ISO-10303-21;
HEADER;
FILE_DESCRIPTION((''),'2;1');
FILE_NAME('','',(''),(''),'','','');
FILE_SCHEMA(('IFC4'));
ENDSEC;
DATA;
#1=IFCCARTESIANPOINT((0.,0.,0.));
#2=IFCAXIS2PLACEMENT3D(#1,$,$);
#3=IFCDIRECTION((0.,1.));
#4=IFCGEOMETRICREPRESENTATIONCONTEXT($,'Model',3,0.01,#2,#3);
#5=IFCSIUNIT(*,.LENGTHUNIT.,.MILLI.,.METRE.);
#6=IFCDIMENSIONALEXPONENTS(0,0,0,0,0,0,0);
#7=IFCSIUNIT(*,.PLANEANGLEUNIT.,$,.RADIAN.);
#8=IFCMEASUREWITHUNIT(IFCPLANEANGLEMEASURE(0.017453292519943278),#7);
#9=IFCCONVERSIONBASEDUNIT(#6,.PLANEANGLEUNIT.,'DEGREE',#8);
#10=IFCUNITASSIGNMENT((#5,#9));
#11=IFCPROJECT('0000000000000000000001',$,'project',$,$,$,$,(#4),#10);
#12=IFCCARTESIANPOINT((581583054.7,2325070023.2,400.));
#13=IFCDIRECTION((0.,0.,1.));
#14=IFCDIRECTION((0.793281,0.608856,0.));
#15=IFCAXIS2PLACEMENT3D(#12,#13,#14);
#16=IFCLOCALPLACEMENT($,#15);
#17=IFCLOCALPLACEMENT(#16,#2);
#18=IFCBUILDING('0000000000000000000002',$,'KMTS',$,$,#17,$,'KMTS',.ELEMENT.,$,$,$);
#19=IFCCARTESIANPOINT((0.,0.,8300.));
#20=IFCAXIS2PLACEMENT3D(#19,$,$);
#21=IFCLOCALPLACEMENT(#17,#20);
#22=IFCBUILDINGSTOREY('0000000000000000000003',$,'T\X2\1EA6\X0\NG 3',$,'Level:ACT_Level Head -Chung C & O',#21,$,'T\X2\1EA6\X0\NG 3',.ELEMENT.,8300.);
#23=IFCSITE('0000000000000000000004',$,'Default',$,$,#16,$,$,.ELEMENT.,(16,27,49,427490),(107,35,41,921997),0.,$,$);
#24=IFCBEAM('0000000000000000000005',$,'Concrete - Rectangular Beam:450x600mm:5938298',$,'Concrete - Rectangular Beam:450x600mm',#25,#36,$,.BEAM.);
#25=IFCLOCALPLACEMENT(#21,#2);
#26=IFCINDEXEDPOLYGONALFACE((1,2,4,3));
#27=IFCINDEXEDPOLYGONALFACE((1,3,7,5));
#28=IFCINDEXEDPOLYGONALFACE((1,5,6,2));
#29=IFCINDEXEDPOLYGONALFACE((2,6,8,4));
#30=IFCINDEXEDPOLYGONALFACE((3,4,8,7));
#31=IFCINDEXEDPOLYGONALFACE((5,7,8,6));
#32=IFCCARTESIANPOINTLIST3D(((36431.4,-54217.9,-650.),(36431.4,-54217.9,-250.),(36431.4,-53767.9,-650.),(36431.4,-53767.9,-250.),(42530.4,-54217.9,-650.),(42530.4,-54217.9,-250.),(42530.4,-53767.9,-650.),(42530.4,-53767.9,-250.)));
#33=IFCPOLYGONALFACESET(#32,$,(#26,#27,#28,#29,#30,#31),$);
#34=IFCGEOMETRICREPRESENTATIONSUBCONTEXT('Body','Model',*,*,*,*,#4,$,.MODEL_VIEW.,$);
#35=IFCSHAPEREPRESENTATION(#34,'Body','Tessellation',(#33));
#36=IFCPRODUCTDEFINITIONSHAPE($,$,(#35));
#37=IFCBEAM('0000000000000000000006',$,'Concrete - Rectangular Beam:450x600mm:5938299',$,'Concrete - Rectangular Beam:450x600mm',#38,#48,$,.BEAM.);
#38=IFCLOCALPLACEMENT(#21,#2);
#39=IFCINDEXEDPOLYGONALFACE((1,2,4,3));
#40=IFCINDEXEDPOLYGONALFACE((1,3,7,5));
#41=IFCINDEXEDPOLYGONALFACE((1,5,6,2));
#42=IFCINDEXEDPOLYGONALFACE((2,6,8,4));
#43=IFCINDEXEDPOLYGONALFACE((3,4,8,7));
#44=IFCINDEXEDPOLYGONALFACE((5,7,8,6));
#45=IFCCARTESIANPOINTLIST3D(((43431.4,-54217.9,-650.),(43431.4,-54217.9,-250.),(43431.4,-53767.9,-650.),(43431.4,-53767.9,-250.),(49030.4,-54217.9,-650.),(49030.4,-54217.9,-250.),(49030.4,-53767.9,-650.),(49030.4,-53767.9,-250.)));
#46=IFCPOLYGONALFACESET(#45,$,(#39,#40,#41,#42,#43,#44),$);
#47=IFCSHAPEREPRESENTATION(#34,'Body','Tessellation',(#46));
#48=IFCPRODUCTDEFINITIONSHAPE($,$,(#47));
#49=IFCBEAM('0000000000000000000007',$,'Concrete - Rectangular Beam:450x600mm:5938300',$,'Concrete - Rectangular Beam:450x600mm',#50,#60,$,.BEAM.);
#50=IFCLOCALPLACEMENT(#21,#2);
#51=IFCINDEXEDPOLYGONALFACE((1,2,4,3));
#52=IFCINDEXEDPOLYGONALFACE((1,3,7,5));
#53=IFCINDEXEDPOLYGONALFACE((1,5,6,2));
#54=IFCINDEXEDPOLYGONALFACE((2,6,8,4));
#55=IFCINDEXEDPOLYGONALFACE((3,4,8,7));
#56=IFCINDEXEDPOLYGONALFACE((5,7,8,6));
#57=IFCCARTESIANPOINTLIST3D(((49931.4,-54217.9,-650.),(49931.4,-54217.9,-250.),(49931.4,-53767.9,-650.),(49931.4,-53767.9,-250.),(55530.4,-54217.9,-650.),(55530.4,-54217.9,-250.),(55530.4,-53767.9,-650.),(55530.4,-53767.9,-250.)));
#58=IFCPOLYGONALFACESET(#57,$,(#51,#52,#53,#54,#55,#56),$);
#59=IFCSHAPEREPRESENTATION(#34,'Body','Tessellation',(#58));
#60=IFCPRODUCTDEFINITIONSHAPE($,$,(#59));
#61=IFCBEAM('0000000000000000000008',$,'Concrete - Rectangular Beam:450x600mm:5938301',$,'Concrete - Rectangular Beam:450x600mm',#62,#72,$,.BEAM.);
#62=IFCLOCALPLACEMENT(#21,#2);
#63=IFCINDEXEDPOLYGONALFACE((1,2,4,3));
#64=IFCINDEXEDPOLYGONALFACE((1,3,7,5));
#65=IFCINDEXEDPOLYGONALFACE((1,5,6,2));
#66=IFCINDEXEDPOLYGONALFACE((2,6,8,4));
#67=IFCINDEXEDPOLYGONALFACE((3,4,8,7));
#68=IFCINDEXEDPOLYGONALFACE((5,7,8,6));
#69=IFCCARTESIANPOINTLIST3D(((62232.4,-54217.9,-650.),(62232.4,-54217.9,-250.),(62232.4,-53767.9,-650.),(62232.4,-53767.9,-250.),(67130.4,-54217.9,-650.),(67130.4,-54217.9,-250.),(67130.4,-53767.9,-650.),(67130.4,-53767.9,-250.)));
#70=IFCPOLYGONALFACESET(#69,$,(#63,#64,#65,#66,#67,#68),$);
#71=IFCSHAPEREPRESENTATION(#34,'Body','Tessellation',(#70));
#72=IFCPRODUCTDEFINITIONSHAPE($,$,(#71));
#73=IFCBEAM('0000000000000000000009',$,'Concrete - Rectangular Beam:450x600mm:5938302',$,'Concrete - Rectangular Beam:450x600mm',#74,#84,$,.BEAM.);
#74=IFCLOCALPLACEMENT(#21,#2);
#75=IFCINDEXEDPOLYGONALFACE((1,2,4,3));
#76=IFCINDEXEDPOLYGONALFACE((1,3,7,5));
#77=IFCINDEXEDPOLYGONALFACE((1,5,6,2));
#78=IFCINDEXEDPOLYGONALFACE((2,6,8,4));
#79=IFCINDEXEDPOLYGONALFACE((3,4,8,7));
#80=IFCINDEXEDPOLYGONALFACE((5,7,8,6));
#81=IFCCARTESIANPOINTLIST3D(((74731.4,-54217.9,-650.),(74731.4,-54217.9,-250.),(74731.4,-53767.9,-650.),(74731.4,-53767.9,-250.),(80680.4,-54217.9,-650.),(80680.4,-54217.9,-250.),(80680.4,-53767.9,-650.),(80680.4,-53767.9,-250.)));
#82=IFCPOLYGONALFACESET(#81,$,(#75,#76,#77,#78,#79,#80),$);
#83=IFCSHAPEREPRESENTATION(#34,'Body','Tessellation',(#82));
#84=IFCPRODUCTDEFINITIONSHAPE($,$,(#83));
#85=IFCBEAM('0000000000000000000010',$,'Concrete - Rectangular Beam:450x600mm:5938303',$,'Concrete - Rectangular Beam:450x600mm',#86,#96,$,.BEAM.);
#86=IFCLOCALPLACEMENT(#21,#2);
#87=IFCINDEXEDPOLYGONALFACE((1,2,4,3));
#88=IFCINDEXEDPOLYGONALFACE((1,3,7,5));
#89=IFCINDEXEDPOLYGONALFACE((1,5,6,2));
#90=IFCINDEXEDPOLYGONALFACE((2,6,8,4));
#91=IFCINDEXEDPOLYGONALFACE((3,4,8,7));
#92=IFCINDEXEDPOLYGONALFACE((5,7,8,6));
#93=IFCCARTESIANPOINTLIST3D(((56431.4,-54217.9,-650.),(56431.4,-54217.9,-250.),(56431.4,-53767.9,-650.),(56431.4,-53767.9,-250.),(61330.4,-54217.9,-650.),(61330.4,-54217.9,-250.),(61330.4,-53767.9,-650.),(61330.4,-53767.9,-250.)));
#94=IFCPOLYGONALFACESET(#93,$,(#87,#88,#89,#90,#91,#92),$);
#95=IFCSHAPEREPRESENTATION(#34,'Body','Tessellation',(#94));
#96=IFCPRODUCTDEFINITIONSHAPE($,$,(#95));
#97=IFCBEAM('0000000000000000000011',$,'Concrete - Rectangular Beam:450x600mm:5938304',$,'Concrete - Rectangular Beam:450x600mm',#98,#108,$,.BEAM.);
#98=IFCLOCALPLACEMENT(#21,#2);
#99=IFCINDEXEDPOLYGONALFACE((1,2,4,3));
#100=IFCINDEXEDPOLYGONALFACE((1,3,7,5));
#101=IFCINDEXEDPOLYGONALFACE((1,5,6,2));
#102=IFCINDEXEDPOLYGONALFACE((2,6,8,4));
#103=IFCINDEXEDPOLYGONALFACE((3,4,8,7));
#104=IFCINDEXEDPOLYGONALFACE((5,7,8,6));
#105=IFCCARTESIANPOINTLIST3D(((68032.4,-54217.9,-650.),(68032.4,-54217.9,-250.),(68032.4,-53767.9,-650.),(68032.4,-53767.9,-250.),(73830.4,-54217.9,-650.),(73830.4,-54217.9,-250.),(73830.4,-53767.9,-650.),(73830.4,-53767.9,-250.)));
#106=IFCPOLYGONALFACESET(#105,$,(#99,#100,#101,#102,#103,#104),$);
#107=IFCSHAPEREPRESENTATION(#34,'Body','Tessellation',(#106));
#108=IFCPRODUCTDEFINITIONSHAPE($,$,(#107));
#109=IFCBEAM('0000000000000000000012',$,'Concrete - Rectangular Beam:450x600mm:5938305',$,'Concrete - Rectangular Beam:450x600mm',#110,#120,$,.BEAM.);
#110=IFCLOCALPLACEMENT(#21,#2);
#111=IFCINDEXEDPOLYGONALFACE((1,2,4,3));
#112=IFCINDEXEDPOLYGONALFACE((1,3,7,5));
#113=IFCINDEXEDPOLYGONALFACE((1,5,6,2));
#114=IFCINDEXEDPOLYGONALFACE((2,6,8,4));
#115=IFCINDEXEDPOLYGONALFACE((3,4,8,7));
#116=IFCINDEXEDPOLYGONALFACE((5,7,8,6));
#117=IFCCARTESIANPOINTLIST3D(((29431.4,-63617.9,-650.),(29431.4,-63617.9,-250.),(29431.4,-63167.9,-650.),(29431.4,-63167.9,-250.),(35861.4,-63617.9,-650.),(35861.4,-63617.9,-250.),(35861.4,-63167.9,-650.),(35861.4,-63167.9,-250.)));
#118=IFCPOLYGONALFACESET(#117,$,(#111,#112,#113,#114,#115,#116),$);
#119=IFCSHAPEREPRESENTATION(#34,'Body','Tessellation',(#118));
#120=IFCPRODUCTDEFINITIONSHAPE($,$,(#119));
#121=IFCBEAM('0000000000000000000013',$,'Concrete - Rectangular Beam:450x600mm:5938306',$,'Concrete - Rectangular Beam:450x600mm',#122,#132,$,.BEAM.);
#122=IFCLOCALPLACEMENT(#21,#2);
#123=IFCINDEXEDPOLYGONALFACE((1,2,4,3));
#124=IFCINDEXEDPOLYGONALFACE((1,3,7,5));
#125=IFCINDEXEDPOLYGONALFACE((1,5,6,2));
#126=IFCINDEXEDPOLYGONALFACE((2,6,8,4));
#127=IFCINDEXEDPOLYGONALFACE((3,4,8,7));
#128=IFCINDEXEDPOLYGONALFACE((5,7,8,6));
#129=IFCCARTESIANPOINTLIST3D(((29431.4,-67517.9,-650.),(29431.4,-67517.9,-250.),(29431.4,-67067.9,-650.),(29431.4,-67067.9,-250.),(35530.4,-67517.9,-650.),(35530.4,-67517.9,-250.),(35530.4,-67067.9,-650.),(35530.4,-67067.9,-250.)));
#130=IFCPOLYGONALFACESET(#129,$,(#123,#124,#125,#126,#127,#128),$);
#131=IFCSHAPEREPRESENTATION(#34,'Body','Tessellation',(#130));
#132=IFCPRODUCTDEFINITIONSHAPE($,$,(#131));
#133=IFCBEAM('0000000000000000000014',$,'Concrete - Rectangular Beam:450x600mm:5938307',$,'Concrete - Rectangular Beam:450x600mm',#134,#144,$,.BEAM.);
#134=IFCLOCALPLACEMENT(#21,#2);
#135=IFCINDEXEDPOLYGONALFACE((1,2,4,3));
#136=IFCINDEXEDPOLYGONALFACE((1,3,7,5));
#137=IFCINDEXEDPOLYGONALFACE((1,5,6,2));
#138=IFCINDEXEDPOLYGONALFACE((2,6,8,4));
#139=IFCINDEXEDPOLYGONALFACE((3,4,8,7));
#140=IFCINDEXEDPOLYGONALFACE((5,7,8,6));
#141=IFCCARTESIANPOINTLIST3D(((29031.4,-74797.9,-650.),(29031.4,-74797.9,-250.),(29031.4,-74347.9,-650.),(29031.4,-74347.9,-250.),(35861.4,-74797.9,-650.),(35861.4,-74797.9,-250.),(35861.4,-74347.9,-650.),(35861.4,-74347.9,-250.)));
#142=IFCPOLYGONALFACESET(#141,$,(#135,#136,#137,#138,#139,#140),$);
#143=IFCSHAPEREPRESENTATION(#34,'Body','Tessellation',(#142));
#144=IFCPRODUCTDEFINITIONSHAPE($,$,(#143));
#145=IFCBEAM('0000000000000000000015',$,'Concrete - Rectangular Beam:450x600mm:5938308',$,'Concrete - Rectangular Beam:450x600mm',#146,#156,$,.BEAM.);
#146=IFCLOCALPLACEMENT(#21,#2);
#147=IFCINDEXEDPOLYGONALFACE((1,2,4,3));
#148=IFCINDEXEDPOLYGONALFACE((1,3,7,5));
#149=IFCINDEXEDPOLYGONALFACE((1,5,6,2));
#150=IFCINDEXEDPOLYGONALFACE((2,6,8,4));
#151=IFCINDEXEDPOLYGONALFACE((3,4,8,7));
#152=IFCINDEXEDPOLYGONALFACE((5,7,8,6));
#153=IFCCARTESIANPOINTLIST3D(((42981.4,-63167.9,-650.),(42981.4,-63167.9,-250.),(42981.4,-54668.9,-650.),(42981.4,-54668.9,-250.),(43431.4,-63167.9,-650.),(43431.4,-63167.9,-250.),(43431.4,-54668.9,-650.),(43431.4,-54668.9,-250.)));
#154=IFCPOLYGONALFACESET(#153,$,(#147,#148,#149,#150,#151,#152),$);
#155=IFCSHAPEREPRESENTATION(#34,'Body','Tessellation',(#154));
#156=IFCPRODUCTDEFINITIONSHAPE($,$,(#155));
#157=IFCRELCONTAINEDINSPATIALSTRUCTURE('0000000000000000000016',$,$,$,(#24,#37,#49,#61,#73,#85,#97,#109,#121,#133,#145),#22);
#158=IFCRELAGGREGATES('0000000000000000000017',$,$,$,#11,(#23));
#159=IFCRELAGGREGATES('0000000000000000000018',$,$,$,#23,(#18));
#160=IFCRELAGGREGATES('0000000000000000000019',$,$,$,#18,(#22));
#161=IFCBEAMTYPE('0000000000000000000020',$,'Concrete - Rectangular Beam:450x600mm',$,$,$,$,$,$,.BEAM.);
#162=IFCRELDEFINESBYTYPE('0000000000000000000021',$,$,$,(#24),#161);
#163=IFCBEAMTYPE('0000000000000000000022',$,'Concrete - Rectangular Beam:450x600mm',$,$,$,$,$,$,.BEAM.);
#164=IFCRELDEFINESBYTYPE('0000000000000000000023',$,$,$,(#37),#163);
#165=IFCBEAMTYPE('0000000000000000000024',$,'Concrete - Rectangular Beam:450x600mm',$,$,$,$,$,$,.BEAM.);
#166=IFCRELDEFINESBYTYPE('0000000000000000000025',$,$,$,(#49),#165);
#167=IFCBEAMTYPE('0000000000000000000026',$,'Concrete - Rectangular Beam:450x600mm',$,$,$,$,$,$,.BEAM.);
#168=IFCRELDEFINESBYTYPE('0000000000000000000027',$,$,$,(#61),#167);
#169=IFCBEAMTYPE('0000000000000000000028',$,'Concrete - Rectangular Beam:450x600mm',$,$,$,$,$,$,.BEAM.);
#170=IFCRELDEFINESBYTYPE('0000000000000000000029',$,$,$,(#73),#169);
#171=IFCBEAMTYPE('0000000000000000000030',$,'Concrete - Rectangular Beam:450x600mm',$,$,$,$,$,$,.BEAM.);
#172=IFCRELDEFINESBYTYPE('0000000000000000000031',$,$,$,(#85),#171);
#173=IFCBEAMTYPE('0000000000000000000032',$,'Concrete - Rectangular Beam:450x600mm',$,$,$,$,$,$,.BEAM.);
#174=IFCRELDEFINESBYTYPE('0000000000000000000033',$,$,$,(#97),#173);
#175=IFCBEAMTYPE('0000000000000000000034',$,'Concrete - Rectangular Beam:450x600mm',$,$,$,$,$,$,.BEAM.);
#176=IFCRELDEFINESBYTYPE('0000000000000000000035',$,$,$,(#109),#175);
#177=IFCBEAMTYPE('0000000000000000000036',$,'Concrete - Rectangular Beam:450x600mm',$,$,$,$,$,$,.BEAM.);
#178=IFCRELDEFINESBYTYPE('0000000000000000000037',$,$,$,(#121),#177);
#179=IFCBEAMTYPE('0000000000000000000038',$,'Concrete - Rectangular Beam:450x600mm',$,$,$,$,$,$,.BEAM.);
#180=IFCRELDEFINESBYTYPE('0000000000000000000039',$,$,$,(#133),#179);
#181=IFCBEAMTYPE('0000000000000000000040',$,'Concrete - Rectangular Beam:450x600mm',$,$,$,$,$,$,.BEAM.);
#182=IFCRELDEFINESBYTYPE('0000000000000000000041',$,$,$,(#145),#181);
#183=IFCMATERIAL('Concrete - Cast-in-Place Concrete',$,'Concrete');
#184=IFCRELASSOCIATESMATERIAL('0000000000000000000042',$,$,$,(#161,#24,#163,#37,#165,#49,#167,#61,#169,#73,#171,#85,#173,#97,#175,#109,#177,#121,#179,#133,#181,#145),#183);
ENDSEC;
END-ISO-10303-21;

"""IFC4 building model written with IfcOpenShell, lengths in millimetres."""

from ifc_helpers import new_model, entity, si_unit, converted_unit, direction, frame, origin, place, context, subcontext, project, spatial, indexed_curve, outline, extrude, source, transform, mapped, material, type_object, type_shapes, element, save


model = new_model("IFC4")

# Units and contexts
model_context = context("Model", 3, precision=0.01, world=origin(), true_north=direction((0.0, 1.0)))
body_context = subcontext(model_context, "Body", "Model", "MODEL_VIEW")
ifc_project = project(units=[si_unit("LENGTHUNIT", "METRE", prefix="MILLI"), converted_unit("PLANEANGLEUNIT", "DEGREE", entity("IfcPlaneAngleMeasure", 0.017453292519943278), si_unit("PLANEANGLEUNIT", "RADIAN"), dimensions=[0, 0, 0, 0, 0, 0, 0])], contexts=[model_context])

# Site, building, storey
site_placement = place(None, frame((581583054.7, 2325070023.2, 400.0), z_axis=(0.0, 0.0, 1.0), x_axis=(0.793281, 0.608856, 0.0)))
site = spatial("IfcSite", under=ifc_project, at=site_placement, Name="Default", CompositionType="ELEMENT", RefLatitude=(16, 27, 49, 427490), RefLongitude=(107, 35, 41, 921997), RefElevation=0.0)
building_placement = place(site_placement, origin())
building = spatial("IfcBuilding", under=site, at=building_placement, Name="KMTS", LongName="KMTS", CompositionType="ELEMENT")
storey_placement = place(building_placement, frame((0.0, 0.0, 8300.0)))
storey = spatial("IfcBuildingStorey", under=building, at=storey_placement, Name="TẦNG 3", ObjectType="Level:ACT_Level Head -Chung C & O", LongName="TẦNG 3", CompositionType="ELEMENT", Elevation=8300.0)

# Beams
ifc_material = material(Name="Concrete - Cast-in-Place Concrete", Category="Concrete")
beam_type_1 = type_object("IfcBeamType", Name="Concrete - Rectangular Beam:450x600mm", PredefinedType="BEAM", material=ifc_material)
shared_shape_1 = source(origin(), body_context, "Body", "SweptSolid", [
    extrude(outline(indexed_curve([(-200.0, -225.0), (200.0, -225.0), (200.0, 225.0), (-200.0, 225.0), (-200.0, -225.0)], self_intersect=False)), frame((36431.4, -53992.9, 7850.0), z_axis=(1.0, 0.0, 0.0), x_axis=(0.0, 0.0, -1.0)), (0.0, 0.0, 1.0), 6099.0),
])
type_shapes(beam_type_1, [shared_shape_1])
beam_1_placement = place(storey_placement, frame((0.0, 0.0, -8300.0)))
element("IfcBeam", 1, at=beam_1_placement, inside=storey, type_object=beam_type_1, material=ifc_material, Name="Concrete - Rectangular Beam:450x600mm:5938298", ObjectType="Concrete - Rectangular Beam:450x600mm", PredefinedType="BEAM", context=body_context, shape_type="MappedRepresentation", body=[
    mapped(shared_shape_1, transform((0.0, 0.0, 0.0), scale=1.0)),
])
beam_type_2 = type_object("IfcBeamType", Name="Concrete - Rectangular Beam:450x600mm", PredefinedType="BEAM", material=ifc_material)
shared_shape_2 = source(origin(), body_context, "Body", "SweptSolid", [
    extrude(outline(indexed_curve([(-200.0, -225.0), (200.0, -225.0), (200.0, 225.0), (-200.0, 225.0), (-200.0, -225.0)], self_intersect=False)), frame((43431.4, -53992.9, 7850.0), z_axis=(1.0, 0.0, 0.0), x_axis=(0.0, 0.0, -1.0)), (0.0, 0.0, 1.0), 5599.0),
])
type_shapes(beam_type_2, [shared_shape_2])
beam_2_placement = place(storey_placement, frame((0.0, 0.0, -8300.0)))
element("IfcBeam", 2, at=beam_2_placement, inside=storey, type_object=beam_type_2, material=ifc_material, Name="Concrete - Rectangular Beam:450x600mm:5938299", ObjectType="Concrete - Rectangular Beam:450x600mm", PredefinedType="BEAM", context=body_context, shape_type="MappedRepresentation", body=[
    mapped(shared_shape_2, transform((0.0, 0.0, 0.0), scale=1.0)),
])
beam_type_3 = type_object("IfcBeamType", Name="Concrete - Rectangular Beam:450x600mm", PredefinedType="BEAM", material=ifc_material)
shared_shape_3 = source(origin(), body_context, "Body", "SweptSolid", [
    extrude(outline(indexed_curve([(-200.0, -225.0), (200.0, -225.0), (200.0, 225.0), (-200.0, 225.0), (-200.0, -225.0)], self_intersect=False)), frame((49931.4, -53992.9, 7850.0), z_axis=(1.0, 0.0, 0.0), x_axis=(0.0, 0.0, -1.0)), (0.0, 0.0, 1.0), 5599.0),
])
type_shapes(beam_type_3, [shared_shape_3])
beam_3_placement = place(storey_placement, frame((0.0, 0.0, -8300.0)))
element("IfcBeam", 3, at=beam_3_placement, inside=storey, type_object=beam_type_3, material=ifc_material, Name="Concrete - Rectangular Beam:450x600mm:5938300", ObjectType="Concrete - Rectangular Beam:450x600mm", PredefinedType="BEAM", context=body_context, shape_type="MappedRepresentation", body=[
    mapped(shared_shape_3, transform((0.0, 0.0, 0.0), scale=1.0)),
])
beam_type_4 = type_object("IfcBeamType", Name="Concrete - Rectangular Beam:450x600mm", PredefinedType="BEAM", material=ifc_material)
shared_shape_4 = source(origin(), body_context, "Body", "SweptSolid", [
    extrude(outline(indexed_curve([(-200.0, -225.0), (200.0, -225.0), (200.0, 225.0), (-200.0, 225.0), (-200.0, -225.0)], self_intersect=False)), frame((62232.4, -53992.9, 7850.0), z_axis=(1.0, 0.0, 0.0), x_axis=(0.0, 0.0, -1.0)), (0.0, 0.0, 1.0), 4898.0),
])
type_shapes(beam_type_4, [shared_shape_4])
beam_4_placement = place(storey_placement, frame((0.0, 0.0, -8300.0)))
element("IfcBeam", 4, at=beam_4_placement, inside=storey, type_object=beam_type_4, material=ifc_material, Name="Concrete - Rectangular Beam:450x600mm:5938301", ObjectType="Concrete - Rectangular Beam:450x600mm", PredefinedType="BEAM", context=body_context, shape_type="MappedRepresentation", body=[
    mapped(shared_shape_4, transform((0.0, 0.0, 0.0), scale=1.0)),
])
beam_type_5 = type_object("IfcBeamType", Name="Concrete - Rectangular Beam:450x600mm", PredefinedType="BEAM", material=ifc_material)
shared_shape_5 = source(origin(), body_context, "Body", "SweptSolid", [
    extrude(outline(indexed_curve([(-200.0, -225.0), (200.0, -225.0), (200.0, 225.0), (-200.0, 225.0), (-200.0, -225.0)], self_intersect=False)), frame((74731.4, -53992.9, 7850.0), z_axis=(1.0, 0.0, 0.0), x_axis=(0.0, 0.0, -1.0)), (0.0, 0.0, 1.0), 5949.0),
])
type_shapes(beam_type_5, [shared_shape_5])
beam_5_placement = place(storey_placement, frame((0.0, 0.0, -8300.0)))
element("IfcBeam", 5, at=beam_5_placement, inside=storey, type_object=beam_type_5, material=ifc_material, Name="Concrete - Rectangular Beam:450x600mm:5938302", ObjectType="Concrete - Rectangular Beam:450x600mm", PredefinedType="BEAM", context=body_context, shape_type="MappedRepresentation", body=[
    mapped(shared_shape_5, transform((0.0, 0.0, 0.0), scale=1.0)),
])
beam_type_6 = type_object("IfcBeamType", Name="Concrete - Rectangular Beam:450x600mm", PredefinedType="BEAM", material=ifc_material)
shared_shape_6 = source(origin(), body_context, "Body", "SweptSolid", [
    extrude(outline(indexed_curve([(-200.0, -225.0), (200.0, -225.0), (200.0, 225.0), (-200.0, 225.0), (-200.0, -225.0)], self_intersect=False)), frame((56431.4, -53992.9, 7850.0), z_axis=(1.0, 0.0, 0.0), x_axis=(0.0, 0.0, -1.0)), (0.0, 0.0, 1.0), 4899.0),
])
type_shapes(beam_type_6, [shared_shape_6])
beam_6_placement = place(storey_placement, frame((0.0, 0.0, -8300.0)))
element("IfcBeam", 6, at=beam_6_placement, inside=storey, type_object=beam_type_6, material=ifc_material, Name="Concrete - Rectangular Beam:450x600mm:5938303", ObjectType="Concrete - Rectangular Beam:450x600mm", PredefinedType="BEAM", context=body_context, shape_type="MappedRepresentation", body=[
    mapped(shared_shape_6, transform((0.0, 0.0, 0.0), scale=1.0)),
])
beam_type_7 = type_object("IfcBeamType", Name="Concrete - Rectangular Beam:450x600mm", PredefinedType="BEAM", material=ifc_material)
shared_shape_7 = source(origin(), body_context, "Body", "SweptSolid", [
    extrude(outline(indexed_curve([(-200.0, -225.0), (200.0, -225.0), (200.0, 225.0), (-200.0, 225.0), (-200.0, -225.0)], self_intersect=False)), frame((68032.4, -53992.9, 7850.0), z_axis=(1.0, 0.0, 0.0), x_axis=(0.0, 0.0, -1.0)), (0.0, 0.0, 1.0), 5798.0),
])
type_shapes(beam_type_7, [shared_shape_7])
beam_7_placement = place(storey_placement, frame((0.0, 0.0, -8300.0)))
element("IfcBeam", 7, at=beam_7_placement, inside=storey, type_object=beam_type_7, material=ifc_material, Name="Concrete - Rectangular Beam:450x600mm:5938304", ObjectType="Concrete - Rectangular Beam:450x600mm", PredefinedType="BEAM", context=body_context, shape_type="MappedRepresentation", body=[
    mapped(shared_shape_7, transform((0.0, 0.0, 0.0), scale=1.0)),
])
beam_type_8 = type_object("IfcBeamType", Name="Concrete - Rectangular Beam:450x600mm", PredefinedType="BEAM", material=ifc_material)
shared_shape_8 = source(origin(), body_context, "Body", "SweptSolid", [
    extrude(outline(indexed_curve([(-200.0, -225.0), (200.0, -225.0), (200.0, 225.0), (-200.0, 225.0), (-200.0, -225.0)], self_intersect=False)), frame((29431.4, -63392.9, 7850.0), z_axis=(1.0, 0.0, 0.0), x_axis=(0.0, 0.0, -1.0)), (0.0, 0.0, 1.0), 6430.0),
])
type_shapes(beam_type_8, [shared_shape_8])
beam_8_placement = place(storey_placement, frame((0.0, 0.0, -8300.0)))
element("IfcBeam", 8, at=beam_8_placement, inside=storey, type_object=beam_type_8, material=ifc_material, Name="Concrete - Rectangular Beam:450x600mm:5938305", ObjectType="Concrete - Rectangular Beam:450x600mm", PredefinedType="BEAM", context=body_context, shape_type="MappedRepresentation", body=[
    mapped(shared_shape_8, transform((0.0, 0.0, 0.0), scale=1.0)),
])
beam_type_9 = type_object("IfcBeamType", Name="Concrete - Rectangular Beam:450x600mm", PredefinedType="BEAM", material=ifc_material)
shared_shape_9 = source(origin(), body_context, "Body", "SweptSolid", [
    extrude(outline(indexed_curve([(-200.0, -225.0), (200.0, -225.0), (200.0, 225.0), (-200.0, 225.0), (-200.0, -225.0)], self_intersect=False)), frame((29431.4, -67292.9, 7850.0), z_axis=(1.0, 0.0, 0.0), x_axis=(0.0, 0.0, -1.0)), (0.0, 0.0, 1.0), 6099.0),
])
type_shapes(beam_type_9, [shared_shape_9])
beam_9_placement = place(storey_placement, frame((0.0, 0.0, -8300.0)))
element("IfcBeam", 9, at=beam_9_placement, inside=storey, type_object=beam_type_9, material=ifc_material, Name="Concrete - Rectangular Beam:450x600mm:5938306", ObjectType="Concrete - Rectangular Beam:450x600mm", PredefinedType="BEAM", context=body_context, shape_type="MappedRepresentation", body=[
    mapped(shared_shape_9, transform((0.0, 0.0, 0.0), scale=1.0)),
])
beam_type_10 = type_object("IfcBeamType", Name="Concrete - Rectangular Beam:450x600mm", PredefinedType="BEAM", material=ifc_material)
shared_shape_10 = source(origin(), body_context, "Body", "SweptSolid", [
    extrude(outline(indexed_curve([(-200.0, -225.0), (200.0, -225.0), (200.0, 225.0), (-200.0, 225.0), (-200.0, -225.0)], self_intersect=False)), frame((29031.4, -74572.9, 7850.0), z_axis=(1.0, 0.0, 0.0), x_axis=(0.0, 0.0, -1.0)), (0.0, 0.0, 1.0), 6830.0),
])
type_shapes(beam_type_10, [shared_shape_10])
beam_10_placement = place(storey_placement, frame((0.0, 0.0, -8300.0)))
element("IfcBeam", 10, at=beam_10_placement, inside=storey, type_object=beam_type_10, material=ifc_material, Name="Concrete - Rectangular Beam:450x600mm:5938307", ObjectType="Concrete - Rectangular Beam:450x600mm", PredefinedType="BEAM", context=body_context, shape_type="MappedRepresentation", body=[
    mapped(shared_shape_10, transform((0.0, 0.0, 0.0), scale=1.0)),
])
beam_type_11 = type_object("IfcBeamType", Name="Concrete - Rectangular Beam:450x600mm", PredefinedType="BEAM", material=ifc_material)
shared_shape_11 = source(origin(), body_context, "Body", "SweptSolid", [
    extrude(outline(indexed_curve([(-225.0, -200.0), (225.0, -200.0), (225.0, 200.0), (-225.0, 200.0), (-225.0, -200.0)], self_intersect=False)), frame((43206.4, -54668.9, 7850.0), z_axis=(0.0, -1.0, 0.0), x_axis=(-1.0, 0.0, 0.0)), (0.0, 0.0, 1.0), 8499.0),
])
type_shapes(beam_type_11, [shared_shape_11])
beam_11_placement = place(storey_placement, frame((0.0, 0.0, -8300.0)))
element("IfcBeam", 11, at=beam_11_placement, inside=storey, type_object=beam_type_11, material=ifc_material, Name="Concrete - Rectangular Beam:450x600mm:5938308", ObjectType="Concrete - Rectangular Beam:450x600mm", PredefinedType="BEAM", context=body_context, shape_type="MappedRepresentation", body=[
    mapped(shared_shape_11, transform((0.0, 0.0, 0.0), scale=1.0)),
])

save(model, "model.ifc")
